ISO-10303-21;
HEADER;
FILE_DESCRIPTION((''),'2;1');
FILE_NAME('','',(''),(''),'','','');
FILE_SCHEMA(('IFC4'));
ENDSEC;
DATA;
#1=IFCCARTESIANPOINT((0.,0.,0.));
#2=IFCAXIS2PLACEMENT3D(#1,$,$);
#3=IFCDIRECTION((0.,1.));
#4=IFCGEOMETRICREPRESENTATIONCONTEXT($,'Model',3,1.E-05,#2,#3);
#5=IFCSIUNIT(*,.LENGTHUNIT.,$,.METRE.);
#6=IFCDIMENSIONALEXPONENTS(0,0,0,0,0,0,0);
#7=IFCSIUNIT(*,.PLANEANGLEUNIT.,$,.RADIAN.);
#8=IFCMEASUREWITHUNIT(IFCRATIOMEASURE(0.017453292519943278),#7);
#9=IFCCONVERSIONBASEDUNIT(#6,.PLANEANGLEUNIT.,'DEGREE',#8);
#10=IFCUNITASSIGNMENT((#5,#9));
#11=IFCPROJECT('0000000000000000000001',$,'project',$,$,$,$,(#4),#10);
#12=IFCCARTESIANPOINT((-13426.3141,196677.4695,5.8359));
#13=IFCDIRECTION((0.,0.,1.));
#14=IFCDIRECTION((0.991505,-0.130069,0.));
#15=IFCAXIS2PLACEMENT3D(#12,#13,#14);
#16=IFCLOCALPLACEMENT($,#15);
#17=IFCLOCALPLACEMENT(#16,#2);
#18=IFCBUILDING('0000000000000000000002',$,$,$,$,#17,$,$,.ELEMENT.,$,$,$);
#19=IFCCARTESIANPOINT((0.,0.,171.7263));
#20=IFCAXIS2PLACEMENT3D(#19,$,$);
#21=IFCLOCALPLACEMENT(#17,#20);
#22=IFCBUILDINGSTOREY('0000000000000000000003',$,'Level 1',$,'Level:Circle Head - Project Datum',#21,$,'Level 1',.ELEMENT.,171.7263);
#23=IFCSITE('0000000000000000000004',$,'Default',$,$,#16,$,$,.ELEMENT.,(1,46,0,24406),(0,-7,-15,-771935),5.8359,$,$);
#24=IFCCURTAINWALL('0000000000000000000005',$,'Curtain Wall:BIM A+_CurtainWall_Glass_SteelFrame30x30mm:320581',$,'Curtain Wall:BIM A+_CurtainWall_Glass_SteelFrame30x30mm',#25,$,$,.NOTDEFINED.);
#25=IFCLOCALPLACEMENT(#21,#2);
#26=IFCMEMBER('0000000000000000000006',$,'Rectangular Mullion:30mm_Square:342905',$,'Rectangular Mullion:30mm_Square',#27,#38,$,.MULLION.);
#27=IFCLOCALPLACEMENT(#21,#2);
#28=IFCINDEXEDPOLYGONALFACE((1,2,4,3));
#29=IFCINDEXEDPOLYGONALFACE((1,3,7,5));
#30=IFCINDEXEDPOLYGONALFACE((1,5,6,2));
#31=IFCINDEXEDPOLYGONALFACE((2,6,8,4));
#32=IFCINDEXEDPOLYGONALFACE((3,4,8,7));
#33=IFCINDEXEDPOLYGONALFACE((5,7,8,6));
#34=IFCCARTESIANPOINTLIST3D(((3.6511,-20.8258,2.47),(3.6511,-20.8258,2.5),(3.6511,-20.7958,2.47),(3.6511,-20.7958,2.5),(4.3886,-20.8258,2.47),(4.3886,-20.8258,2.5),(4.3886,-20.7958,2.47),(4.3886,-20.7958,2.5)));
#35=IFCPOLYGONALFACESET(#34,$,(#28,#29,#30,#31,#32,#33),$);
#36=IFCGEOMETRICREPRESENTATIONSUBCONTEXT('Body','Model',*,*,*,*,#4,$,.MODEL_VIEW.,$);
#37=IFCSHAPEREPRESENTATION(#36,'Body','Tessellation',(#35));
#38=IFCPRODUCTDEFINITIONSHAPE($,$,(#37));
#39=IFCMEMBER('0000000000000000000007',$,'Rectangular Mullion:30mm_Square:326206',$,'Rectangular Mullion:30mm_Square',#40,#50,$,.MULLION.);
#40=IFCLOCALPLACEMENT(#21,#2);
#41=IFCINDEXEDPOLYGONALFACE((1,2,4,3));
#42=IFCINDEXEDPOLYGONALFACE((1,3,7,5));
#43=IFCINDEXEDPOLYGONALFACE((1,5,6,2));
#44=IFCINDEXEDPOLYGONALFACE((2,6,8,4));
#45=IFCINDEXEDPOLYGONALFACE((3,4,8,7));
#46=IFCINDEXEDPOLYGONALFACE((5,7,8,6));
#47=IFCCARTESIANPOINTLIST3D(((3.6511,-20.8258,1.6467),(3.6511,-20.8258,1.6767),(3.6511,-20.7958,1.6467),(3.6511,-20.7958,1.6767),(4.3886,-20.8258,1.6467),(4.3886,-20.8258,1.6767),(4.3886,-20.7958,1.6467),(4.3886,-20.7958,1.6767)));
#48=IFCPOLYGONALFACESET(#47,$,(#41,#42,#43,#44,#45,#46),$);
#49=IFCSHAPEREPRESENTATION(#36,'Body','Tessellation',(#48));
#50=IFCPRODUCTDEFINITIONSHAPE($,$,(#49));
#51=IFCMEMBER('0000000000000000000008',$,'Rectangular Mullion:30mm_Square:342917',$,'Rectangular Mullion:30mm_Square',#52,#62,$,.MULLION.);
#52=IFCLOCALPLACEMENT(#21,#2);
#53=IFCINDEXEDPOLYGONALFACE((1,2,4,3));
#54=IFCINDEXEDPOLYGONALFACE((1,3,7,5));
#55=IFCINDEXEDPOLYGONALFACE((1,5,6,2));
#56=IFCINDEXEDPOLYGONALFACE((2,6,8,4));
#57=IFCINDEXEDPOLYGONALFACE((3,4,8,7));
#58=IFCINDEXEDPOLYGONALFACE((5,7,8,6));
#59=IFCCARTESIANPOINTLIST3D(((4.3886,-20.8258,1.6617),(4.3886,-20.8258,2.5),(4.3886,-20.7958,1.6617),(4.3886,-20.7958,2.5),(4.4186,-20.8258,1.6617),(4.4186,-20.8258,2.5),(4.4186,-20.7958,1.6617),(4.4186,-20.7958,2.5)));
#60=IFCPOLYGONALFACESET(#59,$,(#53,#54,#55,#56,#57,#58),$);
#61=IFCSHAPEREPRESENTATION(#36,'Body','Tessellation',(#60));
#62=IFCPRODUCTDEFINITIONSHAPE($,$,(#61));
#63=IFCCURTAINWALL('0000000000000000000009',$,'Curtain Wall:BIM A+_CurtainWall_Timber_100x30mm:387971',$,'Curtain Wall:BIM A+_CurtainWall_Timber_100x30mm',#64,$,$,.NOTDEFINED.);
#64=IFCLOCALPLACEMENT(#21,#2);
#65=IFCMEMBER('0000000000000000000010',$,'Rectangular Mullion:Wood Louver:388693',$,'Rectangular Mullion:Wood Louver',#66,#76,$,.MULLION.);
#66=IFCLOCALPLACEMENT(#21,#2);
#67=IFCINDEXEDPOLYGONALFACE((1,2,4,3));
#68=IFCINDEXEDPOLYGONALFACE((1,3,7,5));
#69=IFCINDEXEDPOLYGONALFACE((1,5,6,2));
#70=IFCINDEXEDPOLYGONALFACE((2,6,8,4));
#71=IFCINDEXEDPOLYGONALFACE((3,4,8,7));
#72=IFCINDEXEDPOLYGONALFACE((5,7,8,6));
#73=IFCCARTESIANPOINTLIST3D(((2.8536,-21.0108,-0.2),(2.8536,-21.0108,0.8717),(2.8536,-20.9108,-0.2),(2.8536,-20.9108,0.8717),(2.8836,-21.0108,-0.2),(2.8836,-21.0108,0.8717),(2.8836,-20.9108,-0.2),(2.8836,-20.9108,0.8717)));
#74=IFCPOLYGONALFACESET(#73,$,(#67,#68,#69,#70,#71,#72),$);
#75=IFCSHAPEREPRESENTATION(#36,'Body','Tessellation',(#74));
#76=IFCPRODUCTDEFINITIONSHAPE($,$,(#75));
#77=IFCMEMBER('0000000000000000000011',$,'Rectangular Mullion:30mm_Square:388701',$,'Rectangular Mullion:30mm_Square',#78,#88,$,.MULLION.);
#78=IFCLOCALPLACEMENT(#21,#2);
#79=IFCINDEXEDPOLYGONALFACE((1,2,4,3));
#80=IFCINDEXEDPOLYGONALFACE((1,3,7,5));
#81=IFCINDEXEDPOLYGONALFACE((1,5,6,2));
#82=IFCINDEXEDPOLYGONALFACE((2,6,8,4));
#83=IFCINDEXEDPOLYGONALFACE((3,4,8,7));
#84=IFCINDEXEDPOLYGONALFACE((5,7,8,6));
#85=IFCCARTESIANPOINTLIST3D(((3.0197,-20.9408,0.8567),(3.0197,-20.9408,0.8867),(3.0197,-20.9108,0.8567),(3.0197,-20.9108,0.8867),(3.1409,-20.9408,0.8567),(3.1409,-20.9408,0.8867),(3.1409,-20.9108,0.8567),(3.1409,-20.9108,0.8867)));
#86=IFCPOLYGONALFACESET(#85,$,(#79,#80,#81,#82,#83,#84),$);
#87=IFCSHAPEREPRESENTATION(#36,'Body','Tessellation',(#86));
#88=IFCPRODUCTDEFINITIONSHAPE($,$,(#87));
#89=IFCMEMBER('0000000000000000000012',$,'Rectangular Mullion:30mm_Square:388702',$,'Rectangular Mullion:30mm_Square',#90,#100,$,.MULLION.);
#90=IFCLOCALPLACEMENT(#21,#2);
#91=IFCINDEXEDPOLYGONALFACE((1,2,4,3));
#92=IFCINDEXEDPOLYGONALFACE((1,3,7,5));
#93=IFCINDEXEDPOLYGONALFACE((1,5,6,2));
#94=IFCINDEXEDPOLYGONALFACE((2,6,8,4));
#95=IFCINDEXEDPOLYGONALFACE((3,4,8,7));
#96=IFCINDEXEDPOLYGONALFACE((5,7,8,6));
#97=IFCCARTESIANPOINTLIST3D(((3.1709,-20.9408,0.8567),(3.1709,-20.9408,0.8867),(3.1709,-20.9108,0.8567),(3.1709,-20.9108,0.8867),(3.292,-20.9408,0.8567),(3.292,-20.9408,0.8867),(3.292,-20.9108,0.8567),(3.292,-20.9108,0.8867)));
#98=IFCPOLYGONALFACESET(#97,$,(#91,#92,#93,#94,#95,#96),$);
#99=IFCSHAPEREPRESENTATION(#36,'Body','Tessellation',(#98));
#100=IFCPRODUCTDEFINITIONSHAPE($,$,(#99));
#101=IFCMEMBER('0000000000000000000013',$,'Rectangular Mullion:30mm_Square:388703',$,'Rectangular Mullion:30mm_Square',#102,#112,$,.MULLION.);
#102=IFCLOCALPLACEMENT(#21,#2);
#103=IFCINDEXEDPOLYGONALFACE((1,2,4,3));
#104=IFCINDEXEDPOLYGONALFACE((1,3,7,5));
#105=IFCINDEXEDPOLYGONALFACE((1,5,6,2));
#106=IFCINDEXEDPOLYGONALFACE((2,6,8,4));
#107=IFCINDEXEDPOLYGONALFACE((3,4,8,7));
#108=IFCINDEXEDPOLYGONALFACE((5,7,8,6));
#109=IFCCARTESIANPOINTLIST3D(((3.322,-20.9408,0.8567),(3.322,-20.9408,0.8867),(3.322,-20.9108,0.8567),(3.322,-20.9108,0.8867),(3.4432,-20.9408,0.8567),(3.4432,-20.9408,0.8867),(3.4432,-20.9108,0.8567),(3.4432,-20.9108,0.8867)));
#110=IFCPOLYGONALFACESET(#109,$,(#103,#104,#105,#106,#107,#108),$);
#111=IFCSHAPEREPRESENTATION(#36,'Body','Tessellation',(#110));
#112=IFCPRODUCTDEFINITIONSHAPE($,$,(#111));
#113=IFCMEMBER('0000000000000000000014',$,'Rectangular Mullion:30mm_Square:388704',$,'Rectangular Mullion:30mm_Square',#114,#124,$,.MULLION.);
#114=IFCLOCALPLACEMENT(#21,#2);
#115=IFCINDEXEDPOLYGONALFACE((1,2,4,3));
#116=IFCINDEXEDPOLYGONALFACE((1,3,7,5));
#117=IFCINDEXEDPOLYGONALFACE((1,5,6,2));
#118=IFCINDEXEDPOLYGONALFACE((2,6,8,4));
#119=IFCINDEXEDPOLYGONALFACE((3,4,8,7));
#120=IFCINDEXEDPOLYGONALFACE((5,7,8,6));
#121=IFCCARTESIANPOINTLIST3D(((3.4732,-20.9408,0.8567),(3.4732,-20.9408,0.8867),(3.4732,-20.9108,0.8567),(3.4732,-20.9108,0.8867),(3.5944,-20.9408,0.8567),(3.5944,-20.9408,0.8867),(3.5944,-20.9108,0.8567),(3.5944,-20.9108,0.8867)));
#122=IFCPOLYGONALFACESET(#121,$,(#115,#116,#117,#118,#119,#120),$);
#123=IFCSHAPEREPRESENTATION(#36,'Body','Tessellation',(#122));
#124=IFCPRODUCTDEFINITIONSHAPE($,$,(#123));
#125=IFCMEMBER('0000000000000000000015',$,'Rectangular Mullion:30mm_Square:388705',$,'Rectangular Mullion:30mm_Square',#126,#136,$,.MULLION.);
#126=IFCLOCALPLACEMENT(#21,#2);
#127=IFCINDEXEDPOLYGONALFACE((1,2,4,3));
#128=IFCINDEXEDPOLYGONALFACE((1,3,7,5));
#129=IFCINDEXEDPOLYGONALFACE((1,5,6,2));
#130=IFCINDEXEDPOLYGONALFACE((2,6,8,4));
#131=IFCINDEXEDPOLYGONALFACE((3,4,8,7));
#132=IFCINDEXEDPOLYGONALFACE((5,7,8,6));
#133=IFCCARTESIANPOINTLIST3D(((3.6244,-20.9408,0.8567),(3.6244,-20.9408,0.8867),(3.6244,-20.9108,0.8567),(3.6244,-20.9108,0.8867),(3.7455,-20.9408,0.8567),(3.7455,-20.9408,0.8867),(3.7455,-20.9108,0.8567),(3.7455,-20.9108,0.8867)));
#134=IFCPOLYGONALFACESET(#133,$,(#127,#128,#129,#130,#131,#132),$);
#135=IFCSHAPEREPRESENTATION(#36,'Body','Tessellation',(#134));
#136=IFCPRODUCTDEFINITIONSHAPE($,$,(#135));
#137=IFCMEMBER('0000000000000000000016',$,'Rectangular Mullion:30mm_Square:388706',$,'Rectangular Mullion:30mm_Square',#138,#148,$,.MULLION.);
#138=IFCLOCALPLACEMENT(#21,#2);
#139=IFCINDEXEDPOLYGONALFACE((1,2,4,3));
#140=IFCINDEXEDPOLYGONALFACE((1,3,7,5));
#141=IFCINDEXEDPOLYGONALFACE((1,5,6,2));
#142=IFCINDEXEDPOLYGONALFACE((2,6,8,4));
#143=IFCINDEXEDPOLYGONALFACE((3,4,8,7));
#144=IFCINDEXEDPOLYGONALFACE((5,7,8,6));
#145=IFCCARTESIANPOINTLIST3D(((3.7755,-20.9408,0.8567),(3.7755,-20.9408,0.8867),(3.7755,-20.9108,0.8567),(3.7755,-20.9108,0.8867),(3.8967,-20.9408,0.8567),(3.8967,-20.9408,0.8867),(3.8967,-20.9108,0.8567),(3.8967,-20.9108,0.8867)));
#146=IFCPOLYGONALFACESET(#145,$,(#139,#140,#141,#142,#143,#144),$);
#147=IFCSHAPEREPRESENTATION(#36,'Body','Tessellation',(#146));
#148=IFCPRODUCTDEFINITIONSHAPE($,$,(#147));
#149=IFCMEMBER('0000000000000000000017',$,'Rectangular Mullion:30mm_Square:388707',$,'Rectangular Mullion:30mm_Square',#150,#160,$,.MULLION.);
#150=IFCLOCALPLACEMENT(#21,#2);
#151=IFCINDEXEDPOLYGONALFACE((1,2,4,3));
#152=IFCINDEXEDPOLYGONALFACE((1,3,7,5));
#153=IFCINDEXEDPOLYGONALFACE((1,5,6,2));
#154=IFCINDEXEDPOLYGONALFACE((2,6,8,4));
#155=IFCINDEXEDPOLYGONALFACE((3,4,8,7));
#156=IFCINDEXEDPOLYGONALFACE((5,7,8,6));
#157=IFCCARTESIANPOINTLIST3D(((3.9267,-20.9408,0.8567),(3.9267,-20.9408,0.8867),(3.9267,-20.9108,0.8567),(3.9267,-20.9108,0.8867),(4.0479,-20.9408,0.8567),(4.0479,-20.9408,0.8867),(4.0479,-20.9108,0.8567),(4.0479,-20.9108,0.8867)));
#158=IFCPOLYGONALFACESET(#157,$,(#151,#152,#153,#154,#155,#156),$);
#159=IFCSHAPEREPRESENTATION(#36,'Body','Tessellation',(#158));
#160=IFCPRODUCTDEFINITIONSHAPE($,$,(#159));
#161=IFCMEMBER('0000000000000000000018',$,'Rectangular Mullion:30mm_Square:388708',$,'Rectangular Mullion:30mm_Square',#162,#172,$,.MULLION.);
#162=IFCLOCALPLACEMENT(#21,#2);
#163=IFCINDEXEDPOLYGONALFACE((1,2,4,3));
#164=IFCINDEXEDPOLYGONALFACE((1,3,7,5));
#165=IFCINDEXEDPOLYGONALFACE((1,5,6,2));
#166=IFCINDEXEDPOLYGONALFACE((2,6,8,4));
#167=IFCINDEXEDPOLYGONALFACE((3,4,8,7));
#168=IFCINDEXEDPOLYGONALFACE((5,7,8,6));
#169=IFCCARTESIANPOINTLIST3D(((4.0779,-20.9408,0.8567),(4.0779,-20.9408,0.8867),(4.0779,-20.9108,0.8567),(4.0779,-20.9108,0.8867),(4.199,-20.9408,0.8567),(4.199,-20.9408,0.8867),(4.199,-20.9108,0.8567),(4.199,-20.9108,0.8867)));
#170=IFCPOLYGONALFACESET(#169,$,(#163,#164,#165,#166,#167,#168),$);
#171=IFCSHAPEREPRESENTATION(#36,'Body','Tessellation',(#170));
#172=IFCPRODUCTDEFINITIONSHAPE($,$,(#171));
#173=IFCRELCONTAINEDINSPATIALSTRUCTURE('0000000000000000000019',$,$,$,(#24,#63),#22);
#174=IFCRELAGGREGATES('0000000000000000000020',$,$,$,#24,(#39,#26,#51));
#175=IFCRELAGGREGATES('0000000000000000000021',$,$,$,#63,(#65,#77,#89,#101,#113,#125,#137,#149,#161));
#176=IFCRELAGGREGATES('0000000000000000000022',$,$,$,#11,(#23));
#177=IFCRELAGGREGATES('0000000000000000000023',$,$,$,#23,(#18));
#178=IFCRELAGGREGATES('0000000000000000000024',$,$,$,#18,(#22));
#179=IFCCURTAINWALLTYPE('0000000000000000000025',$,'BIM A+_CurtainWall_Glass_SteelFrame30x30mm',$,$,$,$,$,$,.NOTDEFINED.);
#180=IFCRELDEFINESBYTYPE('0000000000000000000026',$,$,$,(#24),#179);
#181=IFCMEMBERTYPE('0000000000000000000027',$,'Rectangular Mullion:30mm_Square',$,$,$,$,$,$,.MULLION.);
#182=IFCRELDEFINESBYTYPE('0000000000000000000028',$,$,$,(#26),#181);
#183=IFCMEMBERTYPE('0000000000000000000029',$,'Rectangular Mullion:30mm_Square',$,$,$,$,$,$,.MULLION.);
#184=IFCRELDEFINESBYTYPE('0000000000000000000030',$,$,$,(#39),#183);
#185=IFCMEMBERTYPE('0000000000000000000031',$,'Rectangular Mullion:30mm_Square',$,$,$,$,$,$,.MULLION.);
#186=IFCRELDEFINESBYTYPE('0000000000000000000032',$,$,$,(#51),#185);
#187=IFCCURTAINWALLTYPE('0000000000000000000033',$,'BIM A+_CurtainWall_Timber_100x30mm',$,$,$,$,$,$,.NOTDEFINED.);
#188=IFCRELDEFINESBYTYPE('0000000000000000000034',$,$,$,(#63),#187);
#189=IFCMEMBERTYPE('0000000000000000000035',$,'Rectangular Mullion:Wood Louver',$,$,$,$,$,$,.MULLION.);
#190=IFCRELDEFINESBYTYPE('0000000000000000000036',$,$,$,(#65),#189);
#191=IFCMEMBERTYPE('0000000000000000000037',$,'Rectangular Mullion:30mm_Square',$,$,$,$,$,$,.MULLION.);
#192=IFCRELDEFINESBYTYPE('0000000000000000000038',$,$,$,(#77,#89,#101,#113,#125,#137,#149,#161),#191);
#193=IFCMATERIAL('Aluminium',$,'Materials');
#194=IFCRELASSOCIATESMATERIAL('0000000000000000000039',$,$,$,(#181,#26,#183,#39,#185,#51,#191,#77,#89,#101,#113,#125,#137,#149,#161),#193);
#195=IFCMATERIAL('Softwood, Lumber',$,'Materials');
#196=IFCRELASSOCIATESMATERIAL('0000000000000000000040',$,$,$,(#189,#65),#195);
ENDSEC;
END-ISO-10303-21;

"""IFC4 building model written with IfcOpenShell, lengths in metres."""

from ifc_helpers import new_model, entity, si_unit, converted_unit, direction, frame, origin, place, context, subcontext, project, spatial, indexed_curve, outline, extrude, source, transform, mapped, material, type_object, type_shapes, element, aggregate, save


model = new_model("IFC4")

# Units and contexts
model_context = context("Model", 3, precision=1e-05, world=origin(), true_north=direction((0.0, 1.0)))
body_context = subcontext(model_context, "Body", "Model", "MODEL_VIEW")
ifc_project = project(units=[si_unit("LENGTHUNIT", "METRE"), converted_unit("PLANEANGLEUNIT", "DEGREE", entity("IfcRatioMeasure", 0.017453292519943278), si_unit("PLANEANGLEUNIT", "RADIAN"), dimensions=[0, 0, 0, 0, 0, 0, 0])], contexts=[model_context])

# Site, building, storey
site_placement = place(None, frame((-13426.3141, 196677.4695, 5.8359), z_axis=(0.0, 0.0, 1.0), x_axis=(0.991505, -0.130069, 0.0)))
site = spatial("IfcSite", under=ifc_project, at=site_placement, Name="Default", CompositionType="ELEMENT", RefLatitude=(1, 46, 0, 24406), RefLongitude=(0, -7, -15, -771935), RefElevation=5.8359)
building_placement = place(site_placement, origin())
building = spatial("IfcBuilding", under=site, at=building_placement, CompositionType="ELEMENT")
storey_placement = place(building_placement, frame((0.0, 0.0, 171.7263)))
storey = spatial("IfcBuildingStorey", under=building, at=storey_placement, Name="Level 1", ObjectType="Level:Circle Head - Project Datum", LongName="Level 1", CompositionType="ELEMENT", Elevation=171.7263)

# Curtain walls, members
curtain_wall_type_1 = type_object("IfcCurtainWallType", Name="BIM A+_CurtainWall_Glass_SteelFrame30x30mm", PredefinedType="NOTDEFINED")
curtain_wall_1_placement = place(storey_placement, frame((0.0, 0.0, -171.7263)))
curtain_wall_1 = element("IfcCurtainWall", 1, at=curtain_wall_1_placement, inside=storey, type_object=curtain_wall_type_1, Name="Curtain Wall:BIM A+_CurtainWall_Glass_SteelFrame30x30mm:320581", ObjectType="Curtain Wall:BIM A+_CurtainWall_Glass_SteelFrame30x30mm", PredefinedType="NOTDEFINED")
ifc_material_1 = material(Name="Aluminium", Category="Materials")
member_type_1 = type_object("IfcMemberType", Name="Rectangular Mullion:30mm_Square", PredefinedType="MULLION", material=ifc_material_1)
shared_shape_1 = source(origin(), body_context, "Body", "SweptSolid", [
    extrude(outline(indexed_curve([(-0.015, -0.015), (0.015, -0.015), (0.015, 0.015), (-0.015, 0.015), (-0.015, -0.015)], self_intersect=False)), frame((-0.015, 0.0, -0.7375), z_axis=(0.0, 0.0, 1.0), x_axis=(0.0, -1.0, 0.0)), (0.0, 0.0, 1.0), 0.7375),
])
type_shapes(member_type_1, [shared_shape_1])
member_1_placement = place(curtain_wall_1_placement, frame((4.3886, -20.8108, 174.2263), z_axis=(1.0, 0.0, 0.0), x_axis=(0.0, 0.0, 1.0)))
member_1 = element("IfcMember", 2, at=member_1_placement, type_object=member_type_1, material=ifc_material_1, Name="Rectangular Mullion:30mm_Square:342905", ObjectType="Rectangular Mullion:30mm_Square", PredefinedType="MULLION", context=body_context, shape_type="MappedRepresentation", body=[
    mapped(shared_shape_1, transform((0.0, 0.0, 0.0), scale=1.0)),
])
member_type_2 = type_object("IfcMemberType", Name="Rectangular Mullion:30mm_Square", PredefinedType="MULLION", material=ifc_material_1)
shared_shape_2 = source(origin(), body_context, "Body", "SweptSolid", [
    extrude(outline(indexed_curve([(-0.015, -0.015), (0.015, -0.015), (0.015, 0.015), (-0.015, 0.015), (-0.015, -0.015)], self_intersect=False)), frame((0.0, 0.0, -0.7375), z_axis=(0.0, 0.0, 1.0), x_axis=(0.0, -1.0, 0.0)), (0.0, 0.0, 1.0), 0.7375),
])
type_shapes(member_type_2, [shared_shape_2])
member_2_placement = place(curtain_wall_1_placement, frame((4.3886, -20.8108, 173.3879), z_axis=(1.0, 0.0, 0.0), x_axis=(0.0, 0.0, 1.0)))
member_2 = element("IfcMember", 3, at=member_2_placement, type_object=member_type_2, material=ifc_material_1, Name="Rectangular Mullion:30mm_Square:326206", ObjectType="Rectangular Mullion:30mm_Square", PredefinedType="MULLION", context=body_context, shape_type="MappedRepresentation", body=[
    mapped(shared_shape_2, transform((0.0, 0.0, 0.0), scale=1.0)),
])
member_type_3 = type_object("IfcMemberType", Name="Rectangular Mullion:30mm_Square", PredefinedType="MULLION", material=ifc_material_1)
shared_shape_3 = source(origin(), body_context, "Body", "SweptSolid", [
    extrude(outline(indexed_curve([(-0.015, -0.015), (0.015, -0.015), (0.015, 0.015), (-0.015, 0.015), (-0.015, -0.015)], self_intersect=False)), frame((0.0, 0.0, -0.8383), z_axis=(0.0, 0.0, 1.0), x_axis=(0.0, -1.0, 0.0)), (0.0, 0.0, 1.0), 0.8383),
])
type_shapes(member_type_3, [shared_shape_3])
member_3_placement = place(curtain_wall_1_placement, frame((4.4036, -20.8108, 173.3879), z_axis=(0.0, 0.0, -1.0), x_axis=(1.0, 0.0, 0.0)))
member_3 = element("IfcMember", 4, at=member_3_placement, type_object=member_type_3, material=ifc_material_1, Name="Rectangular Mullion:30mm_Square:342917", ObjectType="Rectangular Mullion:30mm_Square", PredefinedType="MULLION", context=body_context, shape_type="MappedRepresentation", body=[
    mapped(shared_shape_3, transform((0.0, 0.0, 0.0), scale=1.0)),
])
curtain_wall_type_2 = type_object("IfcCurtainWallType", Name="BIM A+_CurtainWall_Timber_100x30mm", PredefinedType="NOTDEFINED")
curtain_wall_2_placement = place(storey_placement, frame((0.0, 0.0, -171.7263)))
curtain_wall_2 = element("IfcCurtainWall", 5, at=curtain_wall_2_placement, inside=storey, type_object=curtain_wall_type_2, Name="Curtain Wall:BIM A+_CurtainWall_Timber_100x30mm:387971", ObjectType="Curtain Wall:BIM A+_CurtainWall_Timber_100x30mm", PredefinedType="NOTDEFINED")
ifc_material_2 = material(Name="Softwood, Lumber", Category="Materials")
member_type_4 = type_object("IfcMemberType", Name="Rectangular Mullion:Wood Louver", PredefinedType="MULLION", material=ifc_material_2)
shared_shape_4 = source(origin(), body_context, "Body", "SweptSolid", [
    extrude(outline(indexed_curve([(-0.05, -0.015), (0.05, -0.015), (0.05, 0.015), (-0.05, 0.015), (-0.05, -0.015)], self_intersect=False)), frame((-0.015, 0.035, -1.0717), z_axis=(0.0, 0.0, 1.0), x_axis=(0.0, -1.0, 0.0)), (0.0, 0.0, 1.0), 1.0717),
])
type_shapes(member_type_4, [shared_shape_4])
member_4_placement = place(curtain_wall_2_placement, frame((2.8536, -20.9258, 172.598), z_axis=(0.0, 0.0, 1.0), x_axis=(-1.0, 0.0, 0.0)))
member_4 = element("IfcMember", 6, at=member_4_placement, type_object=member_type_4, material=ifc_material_2, Name="Rectangular Mullion:Wood Louver:388693", ObjectType="Rectangular Mullion:Wood Louver", PredefinedType="MULLION", context=body_context, shape_type="MappedRepresentation", body=[
    mapped(shared_shape_4, transform((0.0, 0.0, 0.0), scale=1.0)),
])
member_type_5 = type_object("IfcMemberType", Name="Rectangular Mullion:30mm_Square", PredefinedType="MULLION", material=ifc_material_1)
shared_shape_5 = source(origin(), body_context, "Body", "SweptSolid", [
    extrude(outline(indexed_curve([(-0.015, -0.015), (0.015, -0.015), (0.015, 0.015), (-0.015, 0.015), (-0.015, -0.015)], self_intersect=False)), frame((0.0, 0.0, -0.1212), z_axis=(0.0, 0.0, 1.0), x_axis=(0.0, -1.0, 0.0)), (0.0, 0.0, 1.0), 0.1212),
])
type_shapes(member_type_5, [shared_shape_5])
member_5_placement = place(curtain_wall_2_placement, frame((3.1409, -20.9258, 172.598), z_axis=(1.0, 0.0, 0.0), x_axis=(0.0, 0.0, 1.0)))
member_5 = element("IfcMember", 7, at=member_5_placement, type_object=member_type_5, material=ifc_material_1, Name="Rectangular Mullion:30mm_Square:388701", ObjectType="Rectangular Mullion:30mm_Square", PredefinedType="MULLION", context=body_context, shape_type="MappedRepresentation", body=[
    mapped(shared_shape_5, transform((0.0, 0.0, 0.0), scale=1.0)),
])
member_6_placement = place(curtain_wall_2_placement, frame((3.292, -20.9258, 172.598), z_axis=(1.0, 0.0, 0.0), x_axis=(0.0, 0.0, 1.0)))
member_6 = element("IfcMember", 8, at=member_6_placement, type_object=member_type_5, material=ifc_material_1, Name="Rectangular Mullion:30mm_Square:388702", ObjectType="Rectangular Mullion:30mm_Square", PredefinedType="MULLION", context=body_context, shape_type="MappedRepresentation", body=[
    mapped(shared_shape_5, transform((0.0, 0.0, 0.0), scale=1.0)),
])
member_7_placement = place(curtain_wall_2_placement, frame((3.4432, -20.9258, 172.598), z_axis=(1.0, 0.0, 0.0), x_axis=(0.0, 0.0, 1.0)))
member_7 = element("IfcMember", 9, at=member_7_placement, type_object=member_type_5, material=ifc_material_1, Name="Rectangular Mullion:30mm_Square:388703", ObjectType="Rectangular Mullion:30mm_Square", PredefinedType="MULLION", context=body_context, shape_type="MappedRepresentation", body=[
    mapped(shared_shape_5, transform((0.0, 0.0, 0.0), scale=1.0)),
])
member_8_placement = place(curtain_wall_2_placement, frame((3.5944, -20.9258, 172.598), z_axis=(1.0, 0.0, 0.0), x_axis=(0.0, 0.0, 1.0)))
member_8 = element("IfcMember", 10, at=member_8_placement, type_object=member_type_5, material=ifc_material_1, Name="Rectangular Mullion:30mm_Square:388704", ObjectType="Rectangular Mullion:30mm_Square", PredefinedType="MULLION", context=body_context, shape_type="MappedRepresentation", body=[
    mapped(shared_shape_5, transform((0.0, 0.0, 0.0), scale=1.0)),
])
member_9_placement = place(curtain_wall_2_placement, frame((3.7455, -20.9258, 172.598), z_axis=(1.0, 0.0, 0.0), x_axis=(0.0, 0.0, 1.0)))
member_9 = element("IfcMember", 11, at=member_9_placement, type_object=member_type_5, material=ifc_material_1, Name="Rectangular Mullion:30mm_Square:388705", ObjectType="Rectangular Mullion:30mm_Square", PredefinedType="MULLION", context=body_context, shape_type="MappedRepresentation", body=[
    mapped(shared_shape_5, transform((0.0, 0.0, 0.0), scale=1.0)),
])
member_10_placement = place(curtain_wall_2_placement, frame((3.8967, -20.9258, 172.598), z_axis=(1.0, 0.0, 0.0), x_axis=(0.0, 0.0, 1.0)))
member_10 = element("IfcMember", 12, at=member_10_placement, type_object=member_type_5, material=ifc_material_1, Name="Rectangular Mullion:30mm_Square:388706", ObjectType="Rectangular Mullion:30mm_Square", PredefinedType="MULLION", context=body_context, shape_type="MappedRepresentation", body=[
    mapped(shared_shape_5, transform((0.0, 0.0, 0.0), scale=1.0)),
])
member_11_placement = place(curtain_wall_2_placement, frame((4.0479, -20.9258, 172.598), z_axis=(1.0, 0.0, 0.0), x_axis=(0.0, 0.0, 1.0)))
member_11 = element("IfcMember", 13, at=member_11_placement, type_object=member_type_5, material=ifc_material_1, Name="Rectangular Mullion:30mm_Square:388707", ObjectType="Rectangular Mullion:30mm_Square", PredefinedType="MULLION", context=body_context, shape_type="MappedRepresentation", body=[
    mapped(shared_shape_5, transform((0.0, 0.0, 0.0), scale=1.0)),
])
member_12_placement = place(curtain_wall_2_placement, frame((4.199, -20.9258, 172.598), z_axis=(1.0, 0.0, 0.0), x_axis=(0.0, 0.0, 1.0)))
member_12 = element("IfcMember", 14, at=member_12_placement, type_object=member_type_5, material=ifc_material_1, Name="Rectangular Mullion:30mm_Square:388708", ObjectType="Rectangular Mullion:30mm_Square", PredefinedType="MULLION", context=body_context, shape_type="MappedRepresentation", body=[
    mapped(shared_shape_5, transform((0.0, 0.0, 0.0), scale=1.0)),
])

aggregate(curtain_wall_1, [member_2, member_1, member_3])
aggregate(curtain_wall_2, [member_4, member_5, member_6, member_7, member_8, member_9, member_10, member_11, member_12])

save(model, "model.ifc")
